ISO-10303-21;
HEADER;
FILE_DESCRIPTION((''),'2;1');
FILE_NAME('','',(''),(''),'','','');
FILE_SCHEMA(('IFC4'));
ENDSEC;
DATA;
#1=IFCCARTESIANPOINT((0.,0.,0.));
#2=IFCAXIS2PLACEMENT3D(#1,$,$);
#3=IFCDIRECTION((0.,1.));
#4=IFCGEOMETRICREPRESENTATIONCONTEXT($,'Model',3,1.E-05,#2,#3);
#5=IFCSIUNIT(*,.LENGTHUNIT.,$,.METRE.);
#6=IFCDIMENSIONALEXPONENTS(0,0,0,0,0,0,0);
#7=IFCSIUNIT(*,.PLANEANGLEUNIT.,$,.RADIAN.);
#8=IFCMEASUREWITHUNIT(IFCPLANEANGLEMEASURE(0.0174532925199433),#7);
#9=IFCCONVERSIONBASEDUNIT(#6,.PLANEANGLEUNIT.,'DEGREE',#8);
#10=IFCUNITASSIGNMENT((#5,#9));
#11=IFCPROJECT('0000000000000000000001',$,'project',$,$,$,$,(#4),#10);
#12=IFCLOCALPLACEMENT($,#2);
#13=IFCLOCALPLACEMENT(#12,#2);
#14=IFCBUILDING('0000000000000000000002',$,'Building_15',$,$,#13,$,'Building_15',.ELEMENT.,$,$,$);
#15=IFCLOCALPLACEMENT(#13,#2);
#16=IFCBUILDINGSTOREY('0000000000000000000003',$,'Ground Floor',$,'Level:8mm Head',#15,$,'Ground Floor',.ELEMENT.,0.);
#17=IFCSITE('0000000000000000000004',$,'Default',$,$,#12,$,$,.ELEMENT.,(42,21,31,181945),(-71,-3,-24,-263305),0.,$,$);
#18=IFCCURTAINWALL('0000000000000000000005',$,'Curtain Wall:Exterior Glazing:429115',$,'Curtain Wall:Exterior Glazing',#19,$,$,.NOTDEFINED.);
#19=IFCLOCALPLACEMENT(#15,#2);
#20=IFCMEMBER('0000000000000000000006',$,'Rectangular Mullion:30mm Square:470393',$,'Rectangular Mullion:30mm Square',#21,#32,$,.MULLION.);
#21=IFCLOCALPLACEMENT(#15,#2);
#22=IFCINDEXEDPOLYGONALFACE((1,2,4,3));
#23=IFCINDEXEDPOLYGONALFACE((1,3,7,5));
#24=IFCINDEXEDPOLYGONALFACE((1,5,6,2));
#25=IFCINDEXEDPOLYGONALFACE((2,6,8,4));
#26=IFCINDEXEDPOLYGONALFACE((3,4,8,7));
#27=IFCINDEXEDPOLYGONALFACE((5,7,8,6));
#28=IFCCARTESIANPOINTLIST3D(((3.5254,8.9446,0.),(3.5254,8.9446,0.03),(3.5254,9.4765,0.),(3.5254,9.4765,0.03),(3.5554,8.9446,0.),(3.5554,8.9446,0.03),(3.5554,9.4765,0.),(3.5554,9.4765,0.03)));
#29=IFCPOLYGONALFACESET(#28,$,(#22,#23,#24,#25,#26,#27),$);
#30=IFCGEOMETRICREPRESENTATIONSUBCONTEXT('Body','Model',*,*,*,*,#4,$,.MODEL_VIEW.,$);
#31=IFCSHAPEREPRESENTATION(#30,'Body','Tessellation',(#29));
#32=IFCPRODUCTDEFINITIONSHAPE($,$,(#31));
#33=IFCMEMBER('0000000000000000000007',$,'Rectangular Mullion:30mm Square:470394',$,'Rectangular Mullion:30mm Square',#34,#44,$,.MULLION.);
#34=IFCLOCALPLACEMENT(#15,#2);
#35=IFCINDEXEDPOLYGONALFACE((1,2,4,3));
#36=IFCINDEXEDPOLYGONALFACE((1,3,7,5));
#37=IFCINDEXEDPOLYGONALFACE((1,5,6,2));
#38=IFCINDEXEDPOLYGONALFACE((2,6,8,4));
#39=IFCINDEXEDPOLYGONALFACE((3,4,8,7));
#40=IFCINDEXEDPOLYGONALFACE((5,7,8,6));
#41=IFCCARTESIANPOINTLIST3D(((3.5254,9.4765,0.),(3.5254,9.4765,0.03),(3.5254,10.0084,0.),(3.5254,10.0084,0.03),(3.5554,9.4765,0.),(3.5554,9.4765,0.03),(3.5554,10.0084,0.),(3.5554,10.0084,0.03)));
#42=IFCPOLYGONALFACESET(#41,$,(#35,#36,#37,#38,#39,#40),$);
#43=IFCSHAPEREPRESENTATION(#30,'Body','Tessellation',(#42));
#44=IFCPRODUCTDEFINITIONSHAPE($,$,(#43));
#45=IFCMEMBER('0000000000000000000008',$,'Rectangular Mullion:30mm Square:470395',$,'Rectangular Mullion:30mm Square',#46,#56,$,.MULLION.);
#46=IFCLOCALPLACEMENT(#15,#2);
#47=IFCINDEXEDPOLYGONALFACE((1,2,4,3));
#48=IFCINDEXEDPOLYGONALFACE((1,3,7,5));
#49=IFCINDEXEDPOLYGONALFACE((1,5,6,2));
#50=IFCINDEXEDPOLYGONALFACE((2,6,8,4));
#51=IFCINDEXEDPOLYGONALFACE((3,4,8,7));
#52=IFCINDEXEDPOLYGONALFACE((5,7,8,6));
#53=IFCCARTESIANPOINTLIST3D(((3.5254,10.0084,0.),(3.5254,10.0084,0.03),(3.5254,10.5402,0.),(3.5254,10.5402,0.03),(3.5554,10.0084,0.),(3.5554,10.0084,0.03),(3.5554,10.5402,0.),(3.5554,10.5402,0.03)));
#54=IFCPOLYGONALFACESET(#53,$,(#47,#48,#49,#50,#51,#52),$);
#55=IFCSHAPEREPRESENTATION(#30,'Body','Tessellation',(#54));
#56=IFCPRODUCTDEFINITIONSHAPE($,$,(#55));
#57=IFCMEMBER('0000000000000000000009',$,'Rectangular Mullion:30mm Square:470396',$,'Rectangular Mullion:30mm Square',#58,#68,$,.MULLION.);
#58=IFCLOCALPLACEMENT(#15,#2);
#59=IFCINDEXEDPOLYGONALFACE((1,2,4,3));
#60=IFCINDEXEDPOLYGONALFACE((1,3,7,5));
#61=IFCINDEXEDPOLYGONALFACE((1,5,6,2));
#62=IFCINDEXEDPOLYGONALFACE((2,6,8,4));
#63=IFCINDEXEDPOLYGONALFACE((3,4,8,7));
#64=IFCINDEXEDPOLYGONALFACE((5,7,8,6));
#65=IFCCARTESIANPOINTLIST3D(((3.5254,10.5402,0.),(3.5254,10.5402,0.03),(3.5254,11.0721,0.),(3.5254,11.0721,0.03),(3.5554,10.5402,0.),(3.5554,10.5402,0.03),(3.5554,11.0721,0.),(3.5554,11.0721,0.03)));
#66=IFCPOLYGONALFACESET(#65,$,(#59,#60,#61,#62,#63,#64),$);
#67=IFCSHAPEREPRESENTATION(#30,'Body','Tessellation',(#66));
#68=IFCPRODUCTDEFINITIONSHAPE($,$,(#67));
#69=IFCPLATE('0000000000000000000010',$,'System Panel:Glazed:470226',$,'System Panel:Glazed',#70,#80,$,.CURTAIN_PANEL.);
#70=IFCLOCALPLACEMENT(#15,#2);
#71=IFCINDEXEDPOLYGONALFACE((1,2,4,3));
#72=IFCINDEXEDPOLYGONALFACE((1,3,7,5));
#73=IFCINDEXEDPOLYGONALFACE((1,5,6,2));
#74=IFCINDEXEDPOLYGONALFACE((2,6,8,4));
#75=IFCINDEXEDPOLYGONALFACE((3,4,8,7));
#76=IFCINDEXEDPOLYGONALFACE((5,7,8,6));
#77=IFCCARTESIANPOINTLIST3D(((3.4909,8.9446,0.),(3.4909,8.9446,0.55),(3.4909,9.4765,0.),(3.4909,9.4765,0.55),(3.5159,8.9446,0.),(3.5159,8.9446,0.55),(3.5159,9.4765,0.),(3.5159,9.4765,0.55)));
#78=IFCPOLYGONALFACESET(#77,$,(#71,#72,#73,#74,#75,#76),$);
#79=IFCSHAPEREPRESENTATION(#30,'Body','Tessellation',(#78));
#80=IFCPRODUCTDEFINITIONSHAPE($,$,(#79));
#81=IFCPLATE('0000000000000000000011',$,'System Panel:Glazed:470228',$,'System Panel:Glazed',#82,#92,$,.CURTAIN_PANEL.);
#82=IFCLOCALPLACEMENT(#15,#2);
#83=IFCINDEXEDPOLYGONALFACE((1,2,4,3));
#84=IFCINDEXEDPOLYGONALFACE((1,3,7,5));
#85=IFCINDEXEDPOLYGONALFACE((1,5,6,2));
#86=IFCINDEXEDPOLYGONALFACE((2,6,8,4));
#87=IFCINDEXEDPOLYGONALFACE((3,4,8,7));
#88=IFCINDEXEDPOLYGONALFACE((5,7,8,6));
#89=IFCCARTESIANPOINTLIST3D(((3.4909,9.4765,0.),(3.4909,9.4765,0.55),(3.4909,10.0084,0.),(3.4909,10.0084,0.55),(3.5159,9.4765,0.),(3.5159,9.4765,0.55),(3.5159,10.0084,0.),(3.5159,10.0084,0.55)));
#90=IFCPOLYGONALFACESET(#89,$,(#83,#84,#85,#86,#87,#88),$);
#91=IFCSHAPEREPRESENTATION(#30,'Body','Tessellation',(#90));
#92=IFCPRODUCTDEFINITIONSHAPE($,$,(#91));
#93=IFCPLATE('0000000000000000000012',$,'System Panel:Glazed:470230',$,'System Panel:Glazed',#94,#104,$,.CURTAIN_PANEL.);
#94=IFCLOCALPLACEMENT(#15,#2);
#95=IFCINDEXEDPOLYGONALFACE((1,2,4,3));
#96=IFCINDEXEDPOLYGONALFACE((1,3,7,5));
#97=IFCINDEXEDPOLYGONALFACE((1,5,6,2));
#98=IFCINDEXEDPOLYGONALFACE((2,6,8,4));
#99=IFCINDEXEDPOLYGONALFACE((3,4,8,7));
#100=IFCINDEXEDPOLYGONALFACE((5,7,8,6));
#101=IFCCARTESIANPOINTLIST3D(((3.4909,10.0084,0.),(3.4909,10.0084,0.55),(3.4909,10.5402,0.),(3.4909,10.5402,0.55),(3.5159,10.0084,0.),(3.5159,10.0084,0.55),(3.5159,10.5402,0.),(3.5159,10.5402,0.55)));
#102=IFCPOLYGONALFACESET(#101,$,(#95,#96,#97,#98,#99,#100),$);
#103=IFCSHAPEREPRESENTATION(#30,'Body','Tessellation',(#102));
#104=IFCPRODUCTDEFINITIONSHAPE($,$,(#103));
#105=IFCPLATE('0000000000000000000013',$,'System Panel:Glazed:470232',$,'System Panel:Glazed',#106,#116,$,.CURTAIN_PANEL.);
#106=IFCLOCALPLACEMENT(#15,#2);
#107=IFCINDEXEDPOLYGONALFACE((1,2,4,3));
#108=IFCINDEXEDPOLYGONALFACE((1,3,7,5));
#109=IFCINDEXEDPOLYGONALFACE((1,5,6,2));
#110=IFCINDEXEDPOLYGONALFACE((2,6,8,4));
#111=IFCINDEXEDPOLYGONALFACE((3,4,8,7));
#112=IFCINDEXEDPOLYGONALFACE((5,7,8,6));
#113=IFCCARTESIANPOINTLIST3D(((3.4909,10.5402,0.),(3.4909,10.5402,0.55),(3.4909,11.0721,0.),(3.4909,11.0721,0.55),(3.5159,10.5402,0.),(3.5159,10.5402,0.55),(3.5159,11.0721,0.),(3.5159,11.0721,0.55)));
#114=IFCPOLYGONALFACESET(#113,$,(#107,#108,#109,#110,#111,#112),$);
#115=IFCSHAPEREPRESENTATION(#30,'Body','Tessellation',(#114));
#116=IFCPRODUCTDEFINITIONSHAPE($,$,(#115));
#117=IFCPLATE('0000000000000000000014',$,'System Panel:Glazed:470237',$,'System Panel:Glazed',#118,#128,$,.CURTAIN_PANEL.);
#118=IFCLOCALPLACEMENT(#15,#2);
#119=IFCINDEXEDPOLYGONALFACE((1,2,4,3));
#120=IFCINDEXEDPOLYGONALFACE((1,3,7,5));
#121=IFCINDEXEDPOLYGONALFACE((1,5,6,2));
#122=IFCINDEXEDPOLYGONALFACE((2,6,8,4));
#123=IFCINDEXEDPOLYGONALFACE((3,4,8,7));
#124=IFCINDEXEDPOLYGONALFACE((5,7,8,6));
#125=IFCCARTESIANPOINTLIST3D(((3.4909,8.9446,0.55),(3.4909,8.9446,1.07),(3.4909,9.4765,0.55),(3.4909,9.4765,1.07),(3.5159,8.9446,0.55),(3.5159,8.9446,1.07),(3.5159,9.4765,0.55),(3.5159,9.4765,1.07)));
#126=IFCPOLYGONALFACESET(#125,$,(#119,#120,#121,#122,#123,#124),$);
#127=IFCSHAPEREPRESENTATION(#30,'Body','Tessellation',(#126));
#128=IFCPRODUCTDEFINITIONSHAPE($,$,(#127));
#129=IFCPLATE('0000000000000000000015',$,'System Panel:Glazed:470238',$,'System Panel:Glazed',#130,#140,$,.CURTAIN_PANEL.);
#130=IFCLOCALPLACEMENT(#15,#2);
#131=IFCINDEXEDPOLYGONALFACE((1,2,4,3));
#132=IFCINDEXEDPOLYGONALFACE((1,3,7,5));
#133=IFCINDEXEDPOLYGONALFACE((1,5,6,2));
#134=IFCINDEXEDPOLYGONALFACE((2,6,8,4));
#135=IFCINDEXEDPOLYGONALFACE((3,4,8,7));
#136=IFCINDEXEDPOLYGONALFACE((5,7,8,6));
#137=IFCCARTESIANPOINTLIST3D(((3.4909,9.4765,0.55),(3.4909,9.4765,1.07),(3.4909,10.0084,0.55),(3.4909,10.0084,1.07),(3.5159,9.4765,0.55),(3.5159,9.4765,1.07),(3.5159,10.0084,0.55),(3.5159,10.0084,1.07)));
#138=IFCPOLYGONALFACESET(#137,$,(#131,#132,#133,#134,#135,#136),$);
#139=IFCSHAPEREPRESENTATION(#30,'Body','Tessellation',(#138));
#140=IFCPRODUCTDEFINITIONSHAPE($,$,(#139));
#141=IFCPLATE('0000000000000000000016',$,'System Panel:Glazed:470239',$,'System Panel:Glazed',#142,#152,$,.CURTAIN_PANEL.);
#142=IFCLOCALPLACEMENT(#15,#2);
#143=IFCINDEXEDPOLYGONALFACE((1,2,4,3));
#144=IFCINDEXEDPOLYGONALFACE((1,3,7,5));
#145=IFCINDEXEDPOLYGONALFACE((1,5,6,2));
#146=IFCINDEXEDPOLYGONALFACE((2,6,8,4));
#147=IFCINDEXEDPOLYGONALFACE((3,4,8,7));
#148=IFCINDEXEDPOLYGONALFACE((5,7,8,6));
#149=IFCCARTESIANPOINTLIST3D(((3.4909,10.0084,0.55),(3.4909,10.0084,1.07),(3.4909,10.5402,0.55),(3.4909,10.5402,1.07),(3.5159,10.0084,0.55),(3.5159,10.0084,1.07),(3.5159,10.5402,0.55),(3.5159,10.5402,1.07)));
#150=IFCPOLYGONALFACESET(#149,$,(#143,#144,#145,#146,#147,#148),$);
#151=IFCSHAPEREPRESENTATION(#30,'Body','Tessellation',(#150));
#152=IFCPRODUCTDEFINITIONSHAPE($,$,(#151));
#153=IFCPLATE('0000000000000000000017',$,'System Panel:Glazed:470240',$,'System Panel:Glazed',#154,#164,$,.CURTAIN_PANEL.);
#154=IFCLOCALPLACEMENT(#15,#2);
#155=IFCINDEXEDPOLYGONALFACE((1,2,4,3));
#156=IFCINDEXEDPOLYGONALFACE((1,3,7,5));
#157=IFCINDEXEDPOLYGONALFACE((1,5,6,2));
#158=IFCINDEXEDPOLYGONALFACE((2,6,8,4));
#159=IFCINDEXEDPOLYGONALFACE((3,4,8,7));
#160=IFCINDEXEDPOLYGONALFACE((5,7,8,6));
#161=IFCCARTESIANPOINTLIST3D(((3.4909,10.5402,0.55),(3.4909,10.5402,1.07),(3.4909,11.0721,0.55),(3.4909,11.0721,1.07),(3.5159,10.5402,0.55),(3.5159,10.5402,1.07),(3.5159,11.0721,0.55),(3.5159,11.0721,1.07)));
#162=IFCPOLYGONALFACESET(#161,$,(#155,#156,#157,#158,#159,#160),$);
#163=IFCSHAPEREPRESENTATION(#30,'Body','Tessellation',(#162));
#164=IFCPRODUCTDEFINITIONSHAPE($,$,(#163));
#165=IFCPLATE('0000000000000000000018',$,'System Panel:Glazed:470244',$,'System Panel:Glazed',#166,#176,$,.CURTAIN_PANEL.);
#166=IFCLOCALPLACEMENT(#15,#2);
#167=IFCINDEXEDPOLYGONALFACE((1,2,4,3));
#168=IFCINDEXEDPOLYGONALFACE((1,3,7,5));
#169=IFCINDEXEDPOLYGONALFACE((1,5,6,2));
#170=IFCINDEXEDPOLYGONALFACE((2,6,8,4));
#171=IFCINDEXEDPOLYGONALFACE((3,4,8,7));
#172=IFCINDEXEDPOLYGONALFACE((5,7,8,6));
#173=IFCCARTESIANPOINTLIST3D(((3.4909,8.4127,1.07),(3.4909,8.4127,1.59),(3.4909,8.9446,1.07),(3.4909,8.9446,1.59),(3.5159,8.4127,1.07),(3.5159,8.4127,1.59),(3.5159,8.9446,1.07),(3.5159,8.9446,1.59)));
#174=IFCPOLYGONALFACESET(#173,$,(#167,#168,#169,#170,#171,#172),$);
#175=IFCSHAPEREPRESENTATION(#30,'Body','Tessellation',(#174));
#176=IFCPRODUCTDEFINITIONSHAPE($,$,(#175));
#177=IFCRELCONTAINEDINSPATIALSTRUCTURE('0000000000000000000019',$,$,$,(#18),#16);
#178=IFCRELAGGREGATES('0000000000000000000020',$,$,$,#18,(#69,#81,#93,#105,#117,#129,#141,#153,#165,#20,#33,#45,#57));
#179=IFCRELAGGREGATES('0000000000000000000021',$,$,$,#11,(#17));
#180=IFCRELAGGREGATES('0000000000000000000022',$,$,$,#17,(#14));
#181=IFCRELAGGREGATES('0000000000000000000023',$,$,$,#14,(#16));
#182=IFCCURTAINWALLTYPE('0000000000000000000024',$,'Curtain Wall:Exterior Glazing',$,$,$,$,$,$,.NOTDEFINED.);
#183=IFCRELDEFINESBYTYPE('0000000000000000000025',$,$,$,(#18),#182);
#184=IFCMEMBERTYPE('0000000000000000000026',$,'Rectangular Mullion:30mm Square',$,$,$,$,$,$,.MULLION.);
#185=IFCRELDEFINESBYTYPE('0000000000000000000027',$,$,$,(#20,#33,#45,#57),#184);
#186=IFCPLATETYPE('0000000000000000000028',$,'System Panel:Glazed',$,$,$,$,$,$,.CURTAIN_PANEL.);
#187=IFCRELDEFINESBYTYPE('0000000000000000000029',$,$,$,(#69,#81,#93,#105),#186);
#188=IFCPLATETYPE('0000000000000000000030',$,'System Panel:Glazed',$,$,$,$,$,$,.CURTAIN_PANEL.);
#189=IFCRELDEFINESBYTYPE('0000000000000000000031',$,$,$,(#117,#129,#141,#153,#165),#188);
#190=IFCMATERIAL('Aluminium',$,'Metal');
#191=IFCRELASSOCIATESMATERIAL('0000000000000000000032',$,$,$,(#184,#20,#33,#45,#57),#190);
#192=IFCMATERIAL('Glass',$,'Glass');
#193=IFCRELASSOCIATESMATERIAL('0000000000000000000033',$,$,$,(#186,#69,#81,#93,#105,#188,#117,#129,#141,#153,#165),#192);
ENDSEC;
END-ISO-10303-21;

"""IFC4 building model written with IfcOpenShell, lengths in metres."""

from ifc_helpers import new_model, entity, si_unit, converted_unit, direction, frame, origin, place, context, subcontext, project, spatial, indexed_curve, outline, extrude, source, transform, mapped, material, type_object, type_shapes, element, aggregate, save


model = new_model("IFC4")

# Units and contexts
model_context = context("Model", 3, precision=1e-05, world=origin(), true_north=direction((0.0, 1.0)))
body_context = subcontext(model_context, "Body", "Model", "MODEL_VIEW")
ifc_project = project(units=[si_unit("LENGTHUNIT", "METRE"), converted_unit("PLANEANGLEUNIT", "DEGREE", entity("IfcPlaneAngleMeasure", 0.0174532925199433), si_unit("PLANEANGLEUNIT", "RADIAN"), dimensions=[0, 0, 0, 0, 0, 0, 0])], contexts=[model_context])

# Site, building, storey
site_placement = place(None, origin())
site = spatial("IfcSite", under=ifc_project, at=site_placement, Name="Default", CompositionType="ELEMENT", RefLatitude=(42, 21, 31, 181945), RefLongitude=(-71, -3, -24, -263305), RefElevation=0.0)
building_placement = place(site_placement, origin())
building = spatial("IfcBuilding", under=site, at=building_placement, Name="Building_15", LongName="Building_15", CompositionType="ELEMENT")
storey_placement = place(building_placement, origin())
storey = spatial("IfcBuildingStorey", under=building, at=storey_placement, Name="Ground Floor", ObjectType="Level:8mm Head", LongName="Ground Floor", CompositionType="ELEMENT", Elevation=0.0)

# Curtain wall, members, plates
curtain_wall_type = type_object("IfcCurtainWallType", Name="Curtain Wall:Exterior Glazing", PredefinedType="NOTDEFINED")
curtain_wall_placement = place(storey_placement, origin())
curtain_wall = element("IfcCurtainWall", 1, at=curtain_wall_placement, inside=storey, type_object=curtain_wall_type, Name="Curtain Wall:Exterior Glazing:429115", ObjectType="Curtain Wall:Exterior Glazing", PredefinedType="NOTDEFINED")
ifc_material_1 = material(Name="Aluminium", Category="Metal")
member_type = type_object("IfcMemberType", Name="Rectangular Mullion:30mm Square", PredefinedType="MULLION", material=ifc_material_1)
shared_shape_1 = source(origin(), body_context, "Body", "SweptSolid", [
    extrude(outline(indexed_curve([(-0.015, -0.015), (0.015, -0.015), (0.015, 0.015), (-0.015, 0.015), (-0.015, -0.015)], self_intersect=False)), frame((-0.015, 0.0, -0.5319), z_axis=(0.0, 0.0, 1.0), x_axis=(-1.0, 0.0, 0.0)), (0.0, 0.0, 1.0), 0.5319),
])
type_shapes(member_type, [shared_shape_1])
member_1_placement = place(curtain_wall_placement, frame((3.5404, 8.9446, 0.0), z_axis=(0.0, -1.0, 0.0), x_axis=(0.0, 0.0, -1.0)))
member_1 = element("IfcMember", 2, at=member_1_placement, type_object=member_type, material=ifc_material_1, Name="Rectangular Mullion:30mm Square:470393", ObjectType="Rectangular Mullion:30mm Square", PredefinedType="MULLION", context=body_context, shape_type="MappedRepresentation", body=[
    mapped(shared_shape_1, transform((0.0, 0.0, 0.0), scale=1.0)),
])
member_2_placement = place(curtain_wall_placement, frame((3.5404, 9.4765, 0.0), z_axis=(0.0, -1.0, 0.0), x_axis=(0.0, 0.0, -1.0)))
member_2 = element("IfcMember", 3, at=member_2_placement, type_object=member_type, material=ifc_material_1, Name="Rectangular Mullion:30mm Square:470394", ObjectType="Rectangular Mullion:30mm Square", PredefinedType="MULLION", context=body_context, shape_type="MappedRepresentation", body=[
    mapped(shared_shape_1, transform((0.0, 0.0, 0.0), scale=1.0)),
])
member_3_placement = place(curtain_wall_placement, frame((3.5404, 10.0084, 0.0), z_axis=(0.0, -1.0, 0.0), x_axis=(0.0, 0.0, -1.0)))
member_3 = element("IfcMember", 4, at=member_3_placement, type_object=member_type, material=ifc_material_1, Name="Rectangular Mullion:30mm Square:470395", ObjectType="Rectangular Mullion:30mm Square", PredefinedType="MULLION", context=body_context, shape_type="MappedRepresentation", body=[
    mapped(shared_shape_1, transform((0.0, 0.0, 0.0), scale=1.0)),
])
member_4_placement = place(curtain_wall_placement, frame((3.5404, 10.5402, 0.0), z_axis=(0.0, -1.0, 0.0), x_axis=(0.0, 0.0, -1.0)))
member_4 = element("IfcMember", 5, at=member_4_placement, type_object=member_type, material=ifc_material_1, Name="Rectangular Mullion:30mm Square:470396", ObjectType="Rectangular Mullion:30mm Square", PredefinedType="MULLION", context=body_context, shape_type="MappedRepresentation", body=[
    mapped(shared_shape_1, transform((0.0, 0.0, 0.0), scale=1.0)),
])
ifc_material_2 = material(Name="Glass", Category="Glass")
plate_type_1 = type_object("IfcPlateType", Name="System Panel:Glazed", PredefinedType="CURTAIN_PANEL", material=ifc_material_2)
shared_shape_2 = source(origin(), body_context, "Body", "SweptSolid", [
    extrude(outline(indexed_curve([(-0.0125, -0.2659), (0.0125, -0.2659), (0.0125, 0.2659), (-0.0125, 0.2659), (-0.0125, -0.2659)], self_intersect=False)), frame((0.0, 0.037, 0.0), z_axis=(0.0, 0.0, 1.0), x_axis=(0.0, 1.0, 0.0)), (0.0, 0.0, 1.0), 0.55),
])
type_shapes(plate_type_1, [shared_shape_2])
plate_1_placement = place(curtain_wall_placement, frame((3.5404, 9.2106, 0.0), z_axis=(0.0, 0.0, 1.0), x_axis=(0.0, 1.0, 0.0)))
plate_1 = element("IfcPlate", 6, at=plate_1_placement, type_object=plate_type_1, material=ifc_material_2, Name="System Panel:Glazed:470226", ObjectType="System Panel:Glazed", PredefinedType="CURTAIN_PANEL", context=body_context, shape_type="MappedRepresentation", body=[
    mapped(shared_shape_2, transform((0.0, 0.0, 0.0), scale=1.0)),
])
plate_2_placement = place(curtain_wall_placement, frame((3.5404, 9.7424, 0.0), z_axis=(0.0, 0.0, 1.0), x_axis=(0.0, 1.0, 0.0)))
plate_2 = element("IfcPlate", 7, at=plate_2_placement, type_object=plate_type_1, material=ifc_material_2, Name="System Panel:Glazed:470228", ObjectType="System Panel:Glazed", PredefinedType="CURTAIN_PANEL", context=body_context, shape_type="MappedRepresentation", body=[
    mapped(shared_shape_2, transform((0.0, 0.0, 0.0), scale=1.0)),
])
plate_3_placement = place(curtain_wall_placement, frame((3.5404, 10.2743, 0.0), z_axis=(0.0, 0.0, 1.0), x_axis=(0.0, 1.0, 0.0)))
plate_3 = element("IfcPlate", 8, at=plate_3_placement, type_object=plate_type_1, material=ifc_material_2, Name="System Panel:Glazed:470230", ObjectType="System Panel:Glazed", PredefinedType="CURTAIN_PANEL", context=body_context, shape_type="MappedRepresentation", body=[
    mapped(shared_shape_2, transform((0.0, 0.0, 0.0), scale=1.0)),
])
plate_4_placement = place(curtain_wall_placement, frame((3.5404, 10.8062, 0.0), z_axis=(0.0, 0.0, 1.0), x_axis=(0.0, 1.0, 0.0)))
plate_4 = element("IfcPlate", 9, at=plate_4_placement, type_object=plate_type_1, material=ifc_material_2, Name="System Panel:Glazed:470232", ObjectType="System Panel:Glazed", PredefinedType="CURTAIN_PANEL", context=body_context, shape_type="MappedRepresentation", body=[
    mapped(shared_shape_2, transform((0.0, 0.0, 0.0), scale=1.0)),
])
plate_type_2 = type_object("IfcPlateType", Name="System Panel:Glazed", PredefinedType="CURTAIN_PANEL", material=ifc_material_2)
shared_shape_3 = source(origin(), body_context, "Body", "SweptSolid", [
    extrude(outline(indexed_curve([(-0.0125, -0.2659), (0.0125, -0.2659), (0.0125, 0.2659), (-0.0125, 0.2659), (-0.0125, -0.2659)], self_intersect=False)), frame((0.0, 0.037, 0.0), z_axis=(0.0, 0.0, 1.0), x_axis=(0.0, 1.0, 0.0)), (0.0, 0.0, 1.0), 0.52),
])
type_shapes(plate_type_2, [shared_shape_3])
plate_5_placement = place(curtain_wall_placement, frame((3.5404, 9.2106, 0.55), z_axis=(0.0, 0.0, 1.0), x_axis=(0.0, 1.0, 0.0)))
plate_5 = element("IfcPlate", 10, at=plate_5_placement, type_object=plate_type_2, material=ifc_material_2, Name="System Panel:Glazed:470237", ObjectType="System Panel:Glazed", PredefinedType="CURTAIN_PANEL", context=body_context, shape_type="MappedRepresentation", body=[
    mapped(shared_shape_3, transform((0.0, 0.0, 0.0), scale=1.0)),
])
plate_6_placement = place(curtain_wall_placement, frame((3.5404, 9.7424, 0.55), z_axis=(0.0, 0.0, 1.0), x_axis=(0.0, 1.0, 0.0)))
plate_6 = element("IfcPlate", 11, at=plate_6_placement, type_object=plate_type_2, material=ifc_material_2, Name="System Panel:Glazed:470238", ObjectType="System Panel:Glazed", PredefinedType="CURTAIN_PANEL", context=body_context, shape_type="MappedRepresentation", body=[
    mapped(shared_shape_3, transform((0.0, 0.0, 0.0), scale=1.0)),
])
plate_7_placement = place(curtain_wall_placement, frame((3.5404, 10.2743, 0.55), z_axis=(0.0, 0.0, 1.0), x_axis=(0.0, 1.0, 0.0)))
plate_7 = element("IfcPlate", 12, at=plate_7_placement, type_object=plate_type_2, material=ifc_material_2, Name="System Panel:Glazed:470239", ObjectType="System Panel:Glazed", PredefinedType="CURTAIN_PANEL", context=body_context, shape_type="MappedRepresentation", body=[
    mapped(shared_shape_3, transform((0.0, 0.0, 0.0), scale=1.0)),
])
plate_8_placement = place(curtain_wall_placement, frame((3.5404, 10.8062, 0.55), z_axis=(0.0, 0.0, 1.0), x_axis=(0.0, 1.0, 0.0)))
plate_8 = element("IfcPlate", 13, at=plate_8_placement, type_object=plate_type_2, material=ifc_material_2, Name="System Panel:Glazed:470240", ObjectType="System Panel:Glazed", PredefinedType="CURTAIN_PANEL", context=body_context, shape_type="MappedRepresentation", body=[
    mapped(shared_shape_3, transform((0.0, 0.0, 0.0), scale=1.0)),
])
plate_9_placement = place(curtain_wall_placement, frame((3.5404, 8.6787, 1.07), z_axis=(0.0, 0.0, 1.0), x_axis=(0.0, 1.0, 0.0)))
plate_9 = element("IfcPlate", 14, at=plate_9_placement, type_object=plate_type_2, material=ifc_material_2, Name="System Panel:Glazed:470244", ObjectType="System Panel:Glazed", PredefinedType="CURTAIN_PANEL", context=body_context, shape_type="MappedRepresentation", body=[
    mapped(shared_shape_3, transform((0.0, 0.0, 0.0), scale=1.0)),
])
aggregate(curtain_wall, [plate_1, plate_2, plate_3, plate_4, plate_5, plate_6, plate_7, plate_8, plate_9, member_1, member_2, member_3, member_4])

save(model, "model.ifc")
